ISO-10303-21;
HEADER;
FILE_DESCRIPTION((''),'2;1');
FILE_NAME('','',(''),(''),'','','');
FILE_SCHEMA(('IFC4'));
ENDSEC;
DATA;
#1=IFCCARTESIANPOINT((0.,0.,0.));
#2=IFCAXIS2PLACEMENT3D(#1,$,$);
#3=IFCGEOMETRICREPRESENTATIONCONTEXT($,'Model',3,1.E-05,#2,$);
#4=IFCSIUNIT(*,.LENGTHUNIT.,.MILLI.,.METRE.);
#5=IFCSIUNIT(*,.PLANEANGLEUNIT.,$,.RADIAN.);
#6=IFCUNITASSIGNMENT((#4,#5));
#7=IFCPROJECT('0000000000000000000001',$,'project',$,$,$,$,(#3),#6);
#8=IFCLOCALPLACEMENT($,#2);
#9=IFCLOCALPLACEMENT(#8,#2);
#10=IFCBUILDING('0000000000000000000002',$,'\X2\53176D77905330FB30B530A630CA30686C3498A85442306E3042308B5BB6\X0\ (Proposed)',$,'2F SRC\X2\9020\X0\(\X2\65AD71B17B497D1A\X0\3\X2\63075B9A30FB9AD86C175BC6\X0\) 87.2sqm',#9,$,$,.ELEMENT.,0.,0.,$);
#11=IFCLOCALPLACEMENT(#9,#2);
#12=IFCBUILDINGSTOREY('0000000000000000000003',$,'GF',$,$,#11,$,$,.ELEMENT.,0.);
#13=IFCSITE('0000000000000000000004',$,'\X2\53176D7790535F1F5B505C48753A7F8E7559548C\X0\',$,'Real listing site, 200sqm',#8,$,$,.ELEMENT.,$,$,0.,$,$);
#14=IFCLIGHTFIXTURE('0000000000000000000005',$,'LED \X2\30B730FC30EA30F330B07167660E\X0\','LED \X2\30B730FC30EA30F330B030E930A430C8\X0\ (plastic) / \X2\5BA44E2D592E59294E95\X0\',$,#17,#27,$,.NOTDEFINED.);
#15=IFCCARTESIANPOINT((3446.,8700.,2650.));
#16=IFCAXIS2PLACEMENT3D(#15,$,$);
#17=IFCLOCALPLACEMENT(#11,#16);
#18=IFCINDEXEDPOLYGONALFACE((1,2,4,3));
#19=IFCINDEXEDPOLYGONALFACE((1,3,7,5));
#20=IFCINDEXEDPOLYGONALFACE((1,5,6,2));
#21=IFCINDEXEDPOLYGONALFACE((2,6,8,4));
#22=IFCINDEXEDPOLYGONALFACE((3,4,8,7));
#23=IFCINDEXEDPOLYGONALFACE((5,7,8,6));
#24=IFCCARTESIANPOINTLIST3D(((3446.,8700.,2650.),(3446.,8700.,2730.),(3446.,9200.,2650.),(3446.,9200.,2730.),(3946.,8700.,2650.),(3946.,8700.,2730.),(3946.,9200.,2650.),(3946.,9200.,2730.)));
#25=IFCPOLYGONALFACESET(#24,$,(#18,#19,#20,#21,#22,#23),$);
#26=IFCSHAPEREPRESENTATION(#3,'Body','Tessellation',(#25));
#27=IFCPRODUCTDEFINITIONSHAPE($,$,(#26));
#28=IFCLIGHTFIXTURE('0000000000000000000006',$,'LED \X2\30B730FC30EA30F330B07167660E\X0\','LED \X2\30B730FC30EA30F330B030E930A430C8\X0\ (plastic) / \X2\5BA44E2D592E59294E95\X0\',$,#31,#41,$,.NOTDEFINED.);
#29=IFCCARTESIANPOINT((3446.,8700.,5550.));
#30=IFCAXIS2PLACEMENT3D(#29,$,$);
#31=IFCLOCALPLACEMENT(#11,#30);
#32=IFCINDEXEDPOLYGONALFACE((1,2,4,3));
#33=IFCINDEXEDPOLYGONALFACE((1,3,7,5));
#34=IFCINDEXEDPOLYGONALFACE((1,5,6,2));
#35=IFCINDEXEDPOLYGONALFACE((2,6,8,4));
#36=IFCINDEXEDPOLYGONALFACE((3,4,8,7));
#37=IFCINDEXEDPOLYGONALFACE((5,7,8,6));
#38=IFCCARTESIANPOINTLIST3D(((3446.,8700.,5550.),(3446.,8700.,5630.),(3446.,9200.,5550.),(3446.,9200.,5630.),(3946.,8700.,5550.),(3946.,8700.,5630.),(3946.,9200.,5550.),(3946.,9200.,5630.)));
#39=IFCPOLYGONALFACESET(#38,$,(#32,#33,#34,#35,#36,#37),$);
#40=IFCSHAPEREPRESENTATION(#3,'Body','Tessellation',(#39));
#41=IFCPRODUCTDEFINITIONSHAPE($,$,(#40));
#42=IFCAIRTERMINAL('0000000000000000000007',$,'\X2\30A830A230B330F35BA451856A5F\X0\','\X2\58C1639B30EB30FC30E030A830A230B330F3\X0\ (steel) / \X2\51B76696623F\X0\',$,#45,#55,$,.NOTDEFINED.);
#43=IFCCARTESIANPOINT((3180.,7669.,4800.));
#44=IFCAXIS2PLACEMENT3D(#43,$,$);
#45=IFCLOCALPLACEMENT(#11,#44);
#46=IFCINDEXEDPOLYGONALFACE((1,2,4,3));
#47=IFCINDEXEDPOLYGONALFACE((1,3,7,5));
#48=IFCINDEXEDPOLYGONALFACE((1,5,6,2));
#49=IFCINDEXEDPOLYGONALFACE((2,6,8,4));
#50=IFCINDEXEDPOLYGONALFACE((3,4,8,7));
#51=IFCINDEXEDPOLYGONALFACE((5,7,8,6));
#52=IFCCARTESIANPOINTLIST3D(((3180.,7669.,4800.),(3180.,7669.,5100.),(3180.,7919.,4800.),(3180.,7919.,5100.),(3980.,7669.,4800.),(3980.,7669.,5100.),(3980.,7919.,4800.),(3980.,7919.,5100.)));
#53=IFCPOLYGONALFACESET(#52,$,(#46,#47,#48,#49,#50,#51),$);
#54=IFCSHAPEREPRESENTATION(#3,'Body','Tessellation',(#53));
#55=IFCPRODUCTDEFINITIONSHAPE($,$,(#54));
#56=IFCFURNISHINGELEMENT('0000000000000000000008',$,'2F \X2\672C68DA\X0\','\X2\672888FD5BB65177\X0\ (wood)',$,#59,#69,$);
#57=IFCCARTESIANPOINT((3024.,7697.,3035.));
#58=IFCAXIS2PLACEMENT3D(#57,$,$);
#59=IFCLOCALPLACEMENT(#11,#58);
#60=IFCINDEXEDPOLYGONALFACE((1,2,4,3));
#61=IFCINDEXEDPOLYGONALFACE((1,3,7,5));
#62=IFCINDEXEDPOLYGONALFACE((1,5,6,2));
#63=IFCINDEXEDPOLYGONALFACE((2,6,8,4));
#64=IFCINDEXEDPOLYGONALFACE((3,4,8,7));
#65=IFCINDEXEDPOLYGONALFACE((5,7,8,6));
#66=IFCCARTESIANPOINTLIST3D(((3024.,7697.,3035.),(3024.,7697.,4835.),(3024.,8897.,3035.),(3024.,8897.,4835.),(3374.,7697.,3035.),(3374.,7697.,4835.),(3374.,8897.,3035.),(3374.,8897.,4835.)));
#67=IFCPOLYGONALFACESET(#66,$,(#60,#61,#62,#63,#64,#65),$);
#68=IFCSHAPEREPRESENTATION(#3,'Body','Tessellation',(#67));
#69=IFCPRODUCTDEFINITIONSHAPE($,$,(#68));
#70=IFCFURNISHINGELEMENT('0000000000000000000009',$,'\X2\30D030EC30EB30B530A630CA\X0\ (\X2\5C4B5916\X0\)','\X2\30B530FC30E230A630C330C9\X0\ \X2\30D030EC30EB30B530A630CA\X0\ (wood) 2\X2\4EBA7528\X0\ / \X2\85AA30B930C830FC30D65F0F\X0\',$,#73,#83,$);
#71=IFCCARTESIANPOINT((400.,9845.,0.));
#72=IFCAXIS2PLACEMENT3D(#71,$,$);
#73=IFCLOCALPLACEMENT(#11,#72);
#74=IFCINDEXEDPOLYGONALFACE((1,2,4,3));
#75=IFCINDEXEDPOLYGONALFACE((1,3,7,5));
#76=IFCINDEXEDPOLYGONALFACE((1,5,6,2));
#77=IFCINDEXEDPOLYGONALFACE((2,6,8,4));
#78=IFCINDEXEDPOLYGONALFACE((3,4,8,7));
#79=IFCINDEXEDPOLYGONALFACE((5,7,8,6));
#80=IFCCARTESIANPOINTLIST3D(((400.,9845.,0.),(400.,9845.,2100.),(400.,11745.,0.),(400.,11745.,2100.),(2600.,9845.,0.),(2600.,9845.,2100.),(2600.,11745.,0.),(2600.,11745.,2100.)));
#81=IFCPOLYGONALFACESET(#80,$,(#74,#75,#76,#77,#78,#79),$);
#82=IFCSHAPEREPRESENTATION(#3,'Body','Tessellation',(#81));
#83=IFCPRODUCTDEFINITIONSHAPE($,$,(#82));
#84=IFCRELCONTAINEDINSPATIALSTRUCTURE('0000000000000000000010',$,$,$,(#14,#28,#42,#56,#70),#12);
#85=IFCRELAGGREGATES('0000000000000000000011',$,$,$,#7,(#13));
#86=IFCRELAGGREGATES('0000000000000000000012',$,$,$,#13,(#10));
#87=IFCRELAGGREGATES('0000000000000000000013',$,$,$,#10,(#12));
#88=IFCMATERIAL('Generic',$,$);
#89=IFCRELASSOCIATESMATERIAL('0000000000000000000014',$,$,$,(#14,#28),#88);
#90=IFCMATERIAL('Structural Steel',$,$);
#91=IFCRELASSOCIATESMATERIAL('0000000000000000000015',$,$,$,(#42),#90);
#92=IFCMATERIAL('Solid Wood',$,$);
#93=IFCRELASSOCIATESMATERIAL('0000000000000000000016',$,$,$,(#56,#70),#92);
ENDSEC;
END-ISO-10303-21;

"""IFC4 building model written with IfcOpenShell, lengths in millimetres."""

from ifc_helpers import new_model, si_unit, frame, frame_2d, origin, place, context, project, spatial, rectangle, extrude, material, element, save


model = new_model("IFC4")

# Units and contexts
model_context = context("Model", 3, precision=1e-05, world=origin())
ifc_project = project(units=[si_unit("LENGTHUNIT", "METRE", prefix="MILLI"), si_unit("PLANEANGLEUNIT", "RADIAN")], contexts=[model_context])

# Site, building, storey
site_placement = place(None, origin())
site = spatial("IfcSite", under=ifc_project, at=site_placement, Name="北海道弟子屈町美留和", ObjectType="Real listing site, 200sqm", CompositionType="ELEMENT", RefElevation=0.0)
building_placement = place(site_placement, origin())
building = spatial("IfcBuilding", under=site, at=building_placement, Name="北海道・サウナと水風呂のある家 (Proposed)", ObjectType="2F SRC造(断熱等級3指定・高気密) 87.2sqm", CompositionType="ELEMENT", ElevationOfRefHeight=0.0, ElevationOfTerrain=0.0)
storey_placement = place(building_placement, origin())
storey = spatial("IfcBuildingStorey", under=building, at=storey_placement, Name="GF", CompositionType="ELEMENT", Elevation=0.0)

# Shared definitions
ifc_material_1 = material(Name="Solid Wood")

# Shared definitions
ifc_material_2 = material(Name="Structural Steel")

# Shared definitions
ifc_material_3 = material(Name="Generic")

# Light fixtures
light_fixture_1_placement = place(storey_placement, frame((3446.0, 8700.0, 2650.0)))
element("IfcLightFixture", 1, at=light_fixture_1_placement, inside=storey, material=ifc_material_3, Name="LED シーリング照明", Description="LED シーリングライト (plastic) / 室中央天井", PredefinedType="NOTDEFINED", context=model_context, shape_type="SweptSolid", body=[
    extrude(rectangle(XDim=500.0, YDim=500.0, at=frame_2d((250.0, 250.0))), frame((3446.0, 8700.0, 2650.0)), (0.0, 0.0, 1.0), 80.0),
])
light_fixture_2_placement = place(storey_placement, frame((3446.0, 8700.0, 5550.0)))
element("IfcLightFixture", 2, at=light_fixture_2_placement, inside=storey, material=ifc_material_3, Name="LED シーリング照明", Description="LED シーリングライト (plastic) / 室中央天井", PredefinedType="NOTDEFINED", context=model_context, shape_type="SweptSolid", body=[
    extrude(rectangle(XDim=500.0, YDim=500.0, at=frame_2d((250.0, 250.0))), frame((3446.0, 8700.0, 5550.0)), (0.0, 0.0, 1.0), 80.0),
])

# Air terminal
air_terminal_placement = place(storey_placement, frame((3180.0, 7669.0, 4800.0)))
element("IfcAirTerminal", 3, at=air_terminal_placement, inside=storey, material=ifc_material_2, Name="エアコン室内機", Description="壁掛ルームエアコン (steel) / 冷暖房", PredefinedType="NOTDEFINED", context=model_context, shape_type="SweptSolid", body=[
    extrude(rectangle(XDim=800.0, YDim=250.0, at=frame_2d((400.0, 125.0))), frame((3180.0, 7669.0, 4800.0)), (0.0, 0.0, 1.0), 300.0),
])

# Furnishing elements
furnishing_1_placement = place(storey_placement, frame((3024.0, 7697.0, 3035.0)))
element("IfcFurnishingElement", 4, at=furnishing_1_placement, inside=storey, material=ifc_material_1, Name="2F 本棚", Description="木製家具 (wood)", context=model_context, shape_type="SweptSolid", body=[
    extrude(rectangle(XDim=350.0, YDim=1200.0, at=frame_2d((175.0, 600.0))), frame((3024.0, 7697.0, 3035.0)), (0.0, 0.0, 1.0), 1800.0),
])
furnishing_2_placement = place(storey_placement, frame((400.0, 9845.0, 0.0)))
element("IfcFurnishingElement", 5, at=furnishing_2_placement, inside=storey, material=ifc_material_1, Name="バレルサウナ (屋外)", Description="サーモウッド バレルサウナ (wood) 2人用 / 薪ストーブ式", context=model_context, shape_type="SweptSolid", body=[
    extrude(rectangle(XDim=2200.0, YDim=1900.0, at=frame_2d((1100.0, 950.0))), frame((400.0, 9845.0, 0.0)), (0.0, 0.0, 1.0), 2100.0),
])

save(model, "model.ifc")
